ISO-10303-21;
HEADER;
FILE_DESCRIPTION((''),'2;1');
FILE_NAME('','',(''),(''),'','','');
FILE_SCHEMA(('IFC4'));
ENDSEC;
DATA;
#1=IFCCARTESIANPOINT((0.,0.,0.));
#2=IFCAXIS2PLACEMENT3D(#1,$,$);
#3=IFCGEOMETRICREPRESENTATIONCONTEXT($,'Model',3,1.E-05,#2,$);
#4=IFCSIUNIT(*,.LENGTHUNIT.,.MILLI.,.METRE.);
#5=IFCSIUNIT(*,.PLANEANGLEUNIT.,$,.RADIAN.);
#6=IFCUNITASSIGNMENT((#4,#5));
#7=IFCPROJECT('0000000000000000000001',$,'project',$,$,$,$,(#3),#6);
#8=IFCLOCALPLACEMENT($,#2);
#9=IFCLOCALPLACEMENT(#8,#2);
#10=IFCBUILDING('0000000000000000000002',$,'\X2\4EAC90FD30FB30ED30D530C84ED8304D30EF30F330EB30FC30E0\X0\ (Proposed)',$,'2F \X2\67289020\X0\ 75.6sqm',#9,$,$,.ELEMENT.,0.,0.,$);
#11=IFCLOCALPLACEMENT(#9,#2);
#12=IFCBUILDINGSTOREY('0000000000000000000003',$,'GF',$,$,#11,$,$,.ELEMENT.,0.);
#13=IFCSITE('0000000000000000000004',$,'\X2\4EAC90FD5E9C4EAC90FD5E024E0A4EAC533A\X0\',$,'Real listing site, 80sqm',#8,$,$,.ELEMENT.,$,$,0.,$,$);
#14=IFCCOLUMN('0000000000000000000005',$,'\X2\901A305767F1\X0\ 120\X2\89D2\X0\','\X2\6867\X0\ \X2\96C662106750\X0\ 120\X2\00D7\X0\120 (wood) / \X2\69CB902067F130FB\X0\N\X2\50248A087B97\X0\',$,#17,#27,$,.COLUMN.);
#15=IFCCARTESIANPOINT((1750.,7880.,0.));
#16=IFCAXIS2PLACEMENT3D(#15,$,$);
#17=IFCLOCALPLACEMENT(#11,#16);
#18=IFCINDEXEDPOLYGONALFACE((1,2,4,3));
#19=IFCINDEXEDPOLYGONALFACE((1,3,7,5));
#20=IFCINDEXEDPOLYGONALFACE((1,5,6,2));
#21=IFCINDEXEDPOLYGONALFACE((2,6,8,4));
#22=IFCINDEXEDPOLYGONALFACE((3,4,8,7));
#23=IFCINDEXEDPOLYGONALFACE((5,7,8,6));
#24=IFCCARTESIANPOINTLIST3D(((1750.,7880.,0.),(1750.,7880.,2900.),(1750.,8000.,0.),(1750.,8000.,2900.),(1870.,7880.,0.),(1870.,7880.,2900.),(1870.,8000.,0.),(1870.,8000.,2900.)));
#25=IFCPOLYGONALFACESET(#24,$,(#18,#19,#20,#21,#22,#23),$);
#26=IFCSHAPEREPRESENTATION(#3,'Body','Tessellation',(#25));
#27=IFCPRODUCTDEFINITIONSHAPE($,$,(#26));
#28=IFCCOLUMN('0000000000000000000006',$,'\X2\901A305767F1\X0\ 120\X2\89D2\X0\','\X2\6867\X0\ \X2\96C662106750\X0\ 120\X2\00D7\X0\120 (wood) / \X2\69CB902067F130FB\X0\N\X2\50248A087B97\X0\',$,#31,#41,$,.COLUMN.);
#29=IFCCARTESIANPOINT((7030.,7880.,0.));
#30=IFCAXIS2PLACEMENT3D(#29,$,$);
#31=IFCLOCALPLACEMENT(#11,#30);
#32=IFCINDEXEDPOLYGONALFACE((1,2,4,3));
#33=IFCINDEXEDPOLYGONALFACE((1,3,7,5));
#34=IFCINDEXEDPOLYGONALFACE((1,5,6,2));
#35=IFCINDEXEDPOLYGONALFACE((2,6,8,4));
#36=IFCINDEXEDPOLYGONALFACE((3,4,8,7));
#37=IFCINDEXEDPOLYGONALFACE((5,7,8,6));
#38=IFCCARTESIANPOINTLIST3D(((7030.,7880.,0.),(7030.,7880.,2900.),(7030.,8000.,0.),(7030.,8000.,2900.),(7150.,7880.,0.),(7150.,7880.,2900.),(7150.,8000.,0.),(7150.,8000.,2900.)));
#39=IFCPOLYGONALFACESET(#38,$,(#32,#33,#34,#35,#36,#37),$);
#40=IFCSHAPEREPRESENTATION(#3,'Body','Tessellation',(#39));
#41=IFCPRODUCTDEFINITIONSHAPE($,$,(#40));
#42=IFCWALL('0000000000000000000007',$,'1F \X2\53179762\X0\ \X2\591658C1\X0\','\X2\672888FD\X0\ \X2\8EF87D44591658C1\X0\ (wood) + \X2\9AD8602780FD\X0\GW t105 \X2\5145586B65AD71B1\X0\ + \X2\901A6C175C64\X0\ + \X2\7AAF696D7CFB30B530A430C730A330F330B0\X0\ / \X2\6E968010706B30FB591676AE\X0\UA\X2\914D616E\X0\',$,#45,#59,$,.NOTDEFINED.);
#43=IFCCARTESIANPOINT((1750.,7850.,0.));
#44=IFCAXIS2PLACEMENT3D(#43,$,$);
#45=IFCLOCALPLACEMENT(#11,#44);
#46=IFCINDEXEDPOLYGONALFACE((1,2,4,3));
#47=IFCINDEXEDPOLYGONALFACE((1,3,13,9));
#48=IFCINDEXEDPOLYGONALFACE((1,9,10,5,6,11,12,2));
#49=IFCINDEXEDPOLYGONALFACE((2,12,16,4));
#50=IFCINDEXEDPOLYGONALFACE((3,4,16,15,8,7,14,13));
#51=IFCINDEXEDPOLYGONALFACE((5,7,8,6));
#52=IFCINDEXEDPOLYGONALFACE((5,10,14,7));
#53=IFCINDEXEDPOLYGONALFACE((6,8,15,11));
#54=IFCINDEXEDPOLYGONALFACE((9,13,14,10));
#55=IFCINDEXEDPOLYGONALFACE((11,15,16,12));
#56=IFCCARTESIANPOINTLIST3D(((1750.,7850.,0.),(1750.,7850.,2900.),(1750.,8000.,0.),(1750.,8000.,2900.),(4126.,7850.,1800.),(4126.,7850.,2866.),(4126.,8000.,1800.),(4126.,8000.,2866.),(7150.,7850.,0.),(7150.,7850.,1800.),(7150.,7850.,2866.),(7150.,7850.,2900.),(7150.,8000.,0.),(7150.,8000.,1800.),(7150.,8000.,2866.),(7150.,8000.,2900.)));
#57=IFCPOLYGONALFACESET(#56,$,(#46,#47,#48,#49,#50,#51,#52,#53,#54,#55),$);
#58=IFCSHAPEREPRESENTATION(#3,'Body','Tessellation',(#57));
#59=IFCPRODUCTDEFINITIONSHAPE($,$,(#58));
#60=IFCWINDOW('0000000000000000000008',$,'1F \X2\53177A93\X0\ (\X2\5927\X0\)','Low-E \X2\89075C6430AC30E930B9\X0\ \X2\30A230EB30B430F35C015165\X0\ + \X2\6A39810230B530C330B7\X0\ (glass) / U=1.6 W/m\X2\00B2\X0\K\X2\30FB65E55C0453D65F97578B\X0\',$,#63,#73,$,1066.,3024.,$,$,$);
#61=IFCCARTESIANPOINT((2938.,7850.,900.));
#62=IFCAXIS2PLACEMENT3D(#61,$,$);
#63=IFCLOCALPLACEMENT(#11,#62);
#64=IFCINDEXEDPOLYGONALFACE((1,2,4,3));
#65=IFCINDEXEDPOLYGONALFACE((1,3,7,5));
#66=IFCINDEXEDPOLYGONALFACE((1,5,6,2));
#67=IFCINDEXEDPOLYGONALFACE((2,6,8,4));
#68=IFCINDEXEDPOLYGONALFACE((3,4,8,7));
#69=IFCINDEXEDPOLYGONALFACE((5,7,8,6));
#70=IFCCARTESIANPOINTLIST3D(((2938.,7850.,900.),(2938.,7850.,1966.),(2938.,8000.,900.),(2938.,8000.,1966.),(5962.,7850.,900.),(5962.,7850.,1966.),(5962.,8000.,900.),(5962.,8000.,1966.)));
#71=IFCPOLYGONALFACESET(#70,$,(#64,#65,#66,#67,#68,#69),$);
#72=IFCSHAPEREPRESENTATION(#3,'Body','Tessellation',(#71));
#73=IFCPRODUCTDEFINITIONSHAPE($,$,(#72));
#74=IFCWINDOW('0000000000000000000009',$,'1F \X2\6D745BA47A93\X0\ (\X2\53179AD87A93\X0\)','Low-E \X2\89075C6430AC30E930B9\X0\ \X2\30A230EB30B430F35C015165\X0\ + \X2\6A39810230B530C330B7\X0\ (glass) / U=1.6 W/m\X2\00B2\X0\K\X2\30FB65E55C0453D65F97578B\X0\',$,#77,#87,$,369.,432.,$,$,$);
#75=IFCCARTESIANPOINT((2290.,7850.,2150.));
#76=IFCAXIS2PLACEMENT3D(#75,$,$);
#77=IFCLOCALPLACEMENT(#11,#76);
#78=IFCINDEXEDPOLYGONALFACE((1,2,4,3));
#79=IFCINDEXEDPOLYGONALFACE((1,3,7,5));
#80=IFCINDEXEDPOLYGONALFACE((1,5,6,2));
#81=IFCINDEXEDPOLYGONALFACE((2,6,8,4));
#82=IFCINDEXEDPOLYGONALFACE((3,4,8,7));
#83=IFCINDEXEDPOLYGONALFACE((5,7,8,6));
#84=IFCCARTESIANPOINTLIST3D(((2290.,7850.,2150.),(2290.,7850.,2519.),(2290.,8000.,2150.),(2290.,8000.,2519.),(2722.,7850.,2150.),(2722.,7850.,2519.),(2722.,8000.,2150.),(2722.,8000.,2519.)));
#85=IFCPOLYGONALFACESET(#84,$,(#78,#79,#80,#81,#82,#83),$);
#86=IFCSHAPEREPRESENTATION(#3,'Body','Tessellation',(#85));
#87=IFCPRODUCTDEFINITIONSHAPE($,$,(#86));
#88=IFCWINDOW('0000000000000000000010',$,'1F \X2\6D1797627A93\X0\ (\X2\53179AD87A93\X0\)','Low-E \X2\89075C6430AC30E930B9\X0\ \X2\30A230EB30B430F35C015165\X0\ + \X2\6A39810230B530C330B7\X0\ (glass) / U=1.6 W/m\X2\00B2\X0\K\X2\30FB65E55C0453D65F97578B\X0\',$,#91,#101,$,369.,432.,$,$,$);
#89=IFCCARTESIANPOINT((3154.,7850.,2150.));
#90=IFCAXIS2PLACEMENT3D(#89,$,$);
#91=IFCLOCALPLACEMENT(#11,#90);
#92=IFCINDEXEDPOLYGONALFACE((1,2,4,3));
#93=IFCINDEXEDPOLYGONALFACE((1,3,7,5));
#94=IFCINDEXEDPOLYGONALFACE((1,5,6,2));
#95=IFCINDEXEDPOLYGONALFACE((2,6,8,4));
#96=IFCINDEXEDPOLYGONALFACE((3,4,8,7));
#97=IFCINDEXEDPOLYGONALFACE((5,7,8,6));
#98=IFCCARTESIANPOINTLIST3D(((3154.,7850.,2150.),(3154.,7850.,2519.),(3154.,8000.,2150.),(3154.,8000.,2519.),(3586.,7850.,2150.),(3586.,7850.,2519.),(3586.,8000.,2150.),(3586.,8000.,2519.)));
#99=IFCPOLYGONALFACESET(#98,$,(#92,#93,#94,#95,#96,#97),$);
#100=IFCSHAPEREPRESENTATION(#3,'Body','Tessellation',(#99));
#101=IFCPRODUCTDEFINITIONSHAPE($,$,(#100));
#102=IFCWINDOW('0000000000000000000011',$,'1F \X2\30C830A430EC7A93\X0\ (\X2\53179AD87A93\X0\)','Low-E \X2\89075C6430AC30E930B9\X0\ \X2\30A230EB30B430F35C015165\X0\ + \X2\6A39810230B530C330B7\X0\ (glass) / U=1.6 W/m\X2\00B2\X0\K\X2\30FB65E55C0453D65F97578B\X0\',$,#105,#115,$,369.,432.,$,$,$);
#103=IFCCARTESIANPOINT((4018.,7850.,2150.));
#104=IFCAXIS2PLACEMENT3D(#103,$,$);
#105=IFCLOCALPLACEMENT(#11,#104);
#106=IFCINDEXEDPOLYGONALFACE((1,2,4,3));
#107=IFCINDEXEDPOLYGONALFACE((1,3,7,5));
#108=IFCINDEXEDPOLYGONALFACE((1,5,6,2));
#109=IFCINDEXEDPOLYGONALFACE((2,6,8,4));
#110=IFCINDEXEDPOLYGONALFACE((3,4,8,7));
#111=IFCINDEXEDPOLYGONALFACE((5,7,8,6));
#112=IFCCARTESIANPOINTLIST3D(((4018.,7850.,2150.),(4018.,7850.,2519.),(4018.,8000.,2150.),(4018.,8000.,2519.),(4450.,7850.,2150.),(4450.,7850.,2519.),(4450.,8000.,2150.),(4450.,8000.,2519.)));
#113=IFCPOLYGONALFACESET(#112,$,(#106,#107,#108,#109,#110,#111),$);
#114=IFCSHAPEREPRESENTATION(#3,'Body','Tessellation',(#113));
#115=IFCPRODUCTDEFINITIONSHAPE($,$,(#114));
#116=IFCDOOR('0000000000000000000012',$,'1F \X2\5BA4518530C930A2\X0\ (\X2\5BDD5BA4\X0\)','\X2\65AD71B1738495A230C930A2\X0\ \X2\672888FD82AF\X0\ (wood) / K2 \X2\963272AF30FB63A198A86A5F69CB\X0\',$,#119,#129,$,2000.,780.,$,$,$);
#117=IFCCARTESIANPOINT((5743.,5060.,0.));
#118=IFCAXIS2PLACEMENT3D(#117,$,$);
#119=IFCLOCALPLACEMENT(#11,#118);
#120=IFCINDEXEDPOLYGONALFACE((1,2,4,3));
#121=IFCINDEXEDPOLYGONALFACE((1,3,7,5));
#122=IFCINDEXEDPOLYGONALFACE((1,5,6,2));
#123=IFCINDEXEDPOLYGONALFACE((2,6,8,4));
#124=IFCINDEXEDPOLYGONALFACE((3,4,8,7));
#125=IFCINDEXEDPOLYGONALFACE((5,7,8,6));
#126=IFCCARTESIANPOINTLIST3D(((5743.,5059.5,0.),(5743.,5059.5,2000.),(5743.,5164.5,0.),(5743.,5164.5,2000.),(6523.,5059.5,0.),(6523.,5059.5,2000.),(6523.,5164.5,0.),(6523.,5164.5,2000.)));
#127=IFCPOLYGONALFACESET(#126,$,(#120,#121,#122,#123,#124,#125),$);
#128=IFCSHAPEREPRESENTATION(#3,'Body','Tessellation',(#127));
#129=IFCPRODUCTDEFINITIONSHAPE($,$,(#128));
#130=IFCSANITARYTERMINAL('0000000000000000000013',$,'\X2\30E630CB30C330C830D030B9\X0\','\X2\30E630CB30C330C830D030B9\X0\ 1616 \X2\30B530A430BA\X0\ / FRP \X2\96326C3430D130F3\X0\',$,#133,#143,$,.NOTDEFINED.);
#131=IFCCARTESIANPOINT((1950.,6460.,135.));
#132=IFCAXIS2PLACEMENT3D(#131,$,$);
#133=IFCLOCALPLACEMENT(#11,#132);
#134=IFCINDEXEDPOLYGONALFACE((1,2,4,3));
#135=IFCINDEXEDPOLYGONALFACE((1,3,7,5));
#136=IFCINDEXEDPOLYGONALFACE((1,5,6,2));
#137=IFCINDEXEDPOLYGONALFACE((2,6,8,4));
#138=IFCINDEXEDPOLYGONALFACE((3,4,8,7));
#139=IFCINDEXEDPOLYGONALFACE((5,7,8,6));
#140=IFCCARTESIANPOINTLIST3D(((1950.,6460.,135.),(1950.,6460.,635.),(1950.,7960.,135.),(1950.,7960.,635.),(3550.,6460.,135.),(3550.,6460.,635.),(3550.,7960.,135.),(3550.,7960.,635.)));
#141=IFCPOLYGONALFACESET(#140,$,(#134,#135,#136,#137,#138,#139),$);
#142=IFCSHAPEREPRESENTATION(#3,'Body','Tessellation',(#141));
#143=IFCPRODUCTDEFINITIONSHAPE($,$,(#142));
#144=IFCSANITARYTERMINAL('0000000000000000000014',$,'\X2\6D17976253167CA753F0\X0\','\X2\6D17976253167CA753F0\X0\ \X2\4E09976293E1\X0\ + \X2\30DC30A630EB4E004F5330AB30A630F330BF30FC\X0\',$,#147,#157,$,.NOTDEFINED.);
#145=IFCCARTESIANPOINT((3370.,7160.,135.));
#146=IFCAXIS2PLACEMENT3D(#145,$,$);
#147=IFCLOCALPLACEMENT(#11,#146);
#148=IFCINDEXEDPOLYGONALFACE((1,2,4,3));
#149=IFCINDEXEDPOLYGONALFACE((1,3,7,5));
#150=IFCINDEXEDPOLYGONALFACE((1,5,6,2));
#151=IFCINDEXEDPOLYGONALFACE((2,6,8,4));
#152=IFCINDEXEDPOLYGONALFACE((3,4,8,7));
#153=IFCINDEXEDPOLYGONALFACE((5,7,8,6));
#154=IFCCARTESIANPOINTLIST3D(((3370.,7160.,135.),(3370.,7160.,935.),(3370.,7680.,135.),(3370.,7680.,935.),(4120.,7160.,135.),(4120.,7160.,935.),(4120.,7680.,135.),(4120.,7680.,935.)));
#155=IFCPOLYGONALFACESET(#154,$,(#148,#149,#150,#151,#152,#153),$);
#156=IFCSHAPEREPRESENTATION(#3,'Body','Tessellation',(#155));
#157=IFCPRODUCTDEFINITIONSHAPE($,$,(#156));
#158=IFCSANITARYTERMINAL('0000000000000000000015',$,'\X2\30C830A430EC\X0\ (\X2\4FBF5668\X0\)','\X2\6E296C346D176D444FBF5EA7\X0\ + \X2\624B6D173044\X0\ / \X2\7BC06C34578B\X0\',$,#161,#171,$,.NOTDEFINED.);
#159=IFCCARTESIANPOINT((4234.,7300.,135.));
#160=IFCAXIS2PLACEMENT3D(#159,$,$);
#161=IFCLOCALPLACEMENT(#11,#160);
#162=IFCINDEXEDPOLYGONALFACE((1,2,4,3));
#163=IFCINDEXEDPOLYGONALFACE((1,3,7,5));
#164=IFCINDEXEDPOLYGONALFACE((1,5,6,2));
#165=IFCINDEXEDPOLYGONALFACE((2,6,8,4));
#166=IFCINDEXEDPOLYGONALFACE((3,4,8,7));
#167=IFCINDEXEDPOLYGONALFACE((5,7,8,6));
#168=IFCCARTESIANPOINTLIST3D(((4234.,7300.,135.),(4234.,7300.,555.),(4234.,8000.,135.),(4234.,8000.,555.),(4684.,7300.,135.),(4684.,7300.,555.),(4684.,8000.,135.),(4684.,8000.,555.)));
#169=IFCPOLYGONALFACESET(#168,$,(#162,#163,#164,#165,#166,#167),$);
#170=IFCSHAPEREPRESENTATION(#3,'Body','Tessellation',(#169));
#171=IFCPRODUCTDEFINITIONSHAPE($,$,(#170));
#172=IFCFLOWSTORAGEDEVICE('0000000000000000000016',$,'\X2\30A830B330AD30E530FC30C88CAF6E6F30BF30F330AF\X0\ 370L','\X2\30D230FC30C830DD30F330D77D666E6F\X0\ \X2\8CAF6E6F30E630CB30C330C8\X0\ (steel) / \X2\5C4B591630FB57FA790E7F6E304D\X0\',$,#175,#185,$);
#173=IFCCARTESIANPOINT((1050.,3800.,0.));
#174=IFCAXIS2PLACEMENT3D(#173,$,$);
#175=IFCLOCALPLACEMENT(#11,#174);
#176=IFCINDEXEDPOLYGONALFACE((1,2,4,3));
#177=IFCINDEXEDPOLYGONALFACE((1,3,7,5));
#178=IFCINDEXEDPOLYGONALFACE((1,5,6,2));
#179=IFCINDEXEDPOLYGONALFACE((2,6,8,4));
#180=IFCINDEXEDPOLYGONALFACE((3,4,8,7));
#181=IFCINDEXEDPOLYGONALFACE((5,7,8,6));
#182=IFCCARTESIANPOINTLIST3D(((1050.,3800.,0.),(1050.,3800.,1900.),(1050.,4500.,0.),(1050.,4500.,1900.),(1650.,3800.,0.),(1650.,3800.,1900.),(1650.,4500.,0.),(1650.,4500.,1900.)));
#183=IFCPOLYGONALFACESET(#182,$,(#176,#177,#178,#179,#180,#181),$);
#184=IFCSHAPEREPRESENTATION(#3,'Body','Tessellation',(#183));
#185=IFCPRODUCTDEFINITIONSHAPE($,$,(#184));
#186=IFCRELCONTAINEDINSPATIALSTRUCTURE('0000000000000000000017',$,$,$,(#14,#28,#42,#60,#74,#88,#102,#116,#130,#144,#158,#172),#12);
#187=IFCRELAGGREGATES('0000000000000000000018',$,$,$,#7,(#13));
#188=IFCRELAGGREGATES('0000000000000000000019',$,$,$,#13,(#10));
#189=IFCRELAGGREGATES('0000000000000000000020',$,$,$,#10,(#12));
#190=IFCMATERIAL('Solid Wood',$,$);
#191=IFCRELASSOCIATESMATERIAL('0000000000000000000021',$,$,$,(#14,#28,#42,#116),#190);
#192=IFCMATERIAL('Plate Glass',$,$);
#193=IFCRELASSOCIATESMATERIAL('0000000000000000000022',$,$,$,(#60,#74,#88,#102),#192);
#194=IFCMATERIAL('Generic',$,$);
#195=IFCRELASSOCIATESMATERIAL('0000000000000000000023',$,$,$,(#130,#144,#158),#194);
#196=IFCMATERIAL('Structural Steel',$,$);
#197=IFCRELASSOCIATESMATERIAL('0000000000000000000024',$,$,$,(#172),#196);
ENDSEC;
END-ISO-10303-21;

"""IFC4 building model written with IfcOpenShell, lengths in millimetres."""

from ifc_helpers import new_model, si_unit, frame, frame_2d, origin, place, context, project, spatial, rectangle, extrude, material, element, fill, save


model = new_model("IFC4")

# Units and contexts
model_context = context("Model", 3, precision=1e-05, world=origin())
ifc_project = project(units=[si_unit("LENGTHUNIT", "METRE", prefix="MILLI"), si_unit("PLANEANGLEUNIT", "RADIAN")], contexts=[model_context])

# Site, building, storey
site_placement = place(None, origin())
site = spatial("IfcSite", under=ifc_project, at=site_placement, Name="京都府京都市上京区", ObjectType="Real listing site, 80sqm", CompositionType="ELEMENT", RefElevation=0.0)
building_placement = place(site_placement, origin())
building = spatial("IfcBuilding", under=site, at=building_placement, Name="京都・ロフト付きワンルーム (Proposed)", ObjectType="2F 木造 75.6sqm", CompositionType="ELEMENT", ElevationOfRefHeight=0.0, ElevationOfTerrain=0.0)
storey_placement = place(building_placement, origin())
storey = spatial("IfcBuildingStorey", under=building, at=storey_placement, Name="GF", CompositionType="ELEMENT", Elevation=0.0)

# Columns
ifc_material_1 = material(Name="Solid Wood")
column_1_placement = place(storey_placement, frame((1750.0, 7880.0, 0.0)))
element("IfcColumn", 1, at=column_1_placement, inside=storey, material=ifc_material_1, Name="通し柱 120角", Description="桧 集成材 120×120 (wood) / 構造柱・N値計算", PredefinedType="COLUMN", context=model_context, shape_type="SweptSolid", body=[
    extrude(rectangle(XDim=120.0, YDim=120.0, at=frame_2d((60.0, 60.0))), frame((1750.0, 7880.0, 0.0)), (0.0, 0.0, 1.0), 2900.0),
])
column_2_placement = place(storey_placement, frame((7030.0, 7880.0, 0.0)))
element("IfcColumn", 2, at=column_2_placement, inside=storey, material=ifc_material_1, Name="通し柱 120角", Description="桧 集成材 120×120 (wood) / 構造柱・N値計算", PredefinedType="COLUMN", context=model_context, shape_type="SweptSolid", body=[
    extrude(rectangle(XDim=120.0, YDim=120.0, at=frame_2d((60.0, 60.0))), frame((7030.0, 7880.0, 0.0)), (0.0, 0.0, 1.0), 2900.0),
])

# Wall, openings, windows
wall_1_placement = place(storey_placement, frame((1750.0, 7850.0, 0.0)))
wall_1 = element("IfcWall", 3, at=wall_1_placement, inside=storey, material=ifc_material_1, Name="1F 北面 外壁", Description="木製 軸組外壁 (wood) + 高性能GW t105 充填断熱 + 通気層 + 窯業系サイディング / 準耐火・外皮UA配慮", PredefinedType="NOTDEFINED", context=model_context, shape_type="SweptSolid", body=[
    extrude(rectangle(XDim=5400.0, YDim=150.0, at=frame_2d((2700.0, 75.0))), frame((1750.0, 7850.0, 0.0)), (0.0, 0.0, 1.0), 2900.0),
])
opening_1_placement = place(storey_placement, frame((2938.0, 7850.0, 900.0)))
opening_1 = element("IfcOpeningElement", 4, at=opening_1_placement, cuts=wall_1, PredefinedType="NOTDEFINED", context=model_context, shape_type="SweptSolid", body=[
    extrude(rectangle(XDim=3024.0, YDim=150.0, at=frame_2d((1512.0, 75.0))), frame((2938.0, 7850.0, 900.0)), (0.0, 0.0, 1.0), 1066.0),
])
opening_2_placement = place(storey_placement, frame((2290.0, 7850.0, 2150.0)))
opening_2 = element("IfcOpeningElement", 5, at=opening_2_placement, cuts=wall_1, PredefinedType="NOTDEFINED", context=model_context, shape_type="SweptSolid", body=[
    extrude(rectangle(XDim=432.0, YDim=150.0, at=frame_2d((216.0, 75.0))), frame((2290.0, 7850.0, 2150.0)), (0.0, 0.0, 1.0), 369.0),
])
opening_3_placement = place(storey_placement, frame((3154.0, 7850.0, 2150.0)))
opening_3 = element("IfcOpeningElement", 6, at=opening_3_placement, cuts=wall_1, PredefinedType="NOTDEFINED", context=model_context, shape_type="SweptSolid", body=[
    extrude(rectangle(XDim=432.0, YDim=150.0, at=frame_2d((216.0, 75.0))), frame((3154.0, 7850.0, 2150.0)), (0.0, 0.0, 1.0), 369.0),
])
opening_4_placement = place(storey_placement, frame((4018.0, 7850.0, 2150.0)))
opening_4 = element("IfcOpeningElement", 7, at=opening_4_placement, cuts=wall_1, PredefinedType="NOTDEFINED", context=model_context, shape_type="SweptSolid", body=[
    extrude(rectangle(XDim=432.0, YDim=150.0, at=frame_2d((216.0, 75.0))), frame((4018.0, 7850.0, 2150.0)), (0.0, 0.0, 1.0), 369.0),
])
ifc_material_2 = material(Name="Plate Glass")
window_1_placement = place(storey_placement, frame((2938.0, 7850.0, 900.0)))
window_1 = element("IfcWindow", 8, at=window_1_placement, inside=storey, material=ifc_material_2, Name="1F 北窓 (大)", Description="Low-E 複層ガラス アルゴン封入 + 樹脂サッシ (glass) / U=1.6 W/m²K・日射取得型", OverallHeight=1066.0, OverallWidth=3024.0, context=model_context, shape_type="SweptSolid", body=[
    extrude(rectangle(XDim=3024.0, YDim=150.0, at=frame_2d((1512.0, 75.0))), frame((2938.0, 7850.0, 900.0)), (0.0, 0.0, 1.0), 1066.0),
])
fill(opening_1, window_1)
window_2_placement = place(storey_placement, frame((2290.0, 7850.0, 2150.0)))
window_2 = element("IfcWindow", 9, at=window_2_placement, inside=storey, material=ifc_material_2, Name="1F 浴室窓 (北高窓)", Description="Low-E 複層ガラス アルゴン封入 + 樹脂サッシ (glass) / U=1.6 W/m²K・日射取得型", OverallHeight=369.0, OverallWidth=432.0, context=model_context, shape_type="SweptSolid", body=[
    extrude(rectangle(XDim=432.0, YDim=150.0, at=frame_2d((216.0, 75.0))), frame((2290.0, 7850.0, 2150.0)), (0.0, 0.0, 1.0), 369.0),
])
fill(opening_2, window_2)
window_3_placement = place(storey_placement, frame((3154.0, 7850.0, 2150.0)))
window_3 = element("IfcWindow", 10, at=window_3_placement, inside=storey, material=ifc_material_2, Name="1F 洗面窓 (北高窓)", Description="Low-E 複層ガラス アルゴン封入 + 樹脂サッシ (glass) / U=1.6 W/m²K・日射取得型", OverallHeight=369.0, OverallWidth=432.0, context=model_context, shape_type="SweptSolid", body=[
    extrude(rectangle(XDim=432.0, YDim=150.0, at=frame_2d((216.0, 75.0))), frame((3154.0, 7850.0, 2150.0)), (0.0, 0.0, 1.0), 369.0),
])
fill(opening_3, window_3)
window_4_placement = place(storey_placement, frame((4018.0, 7850.0, 2150.0)))
window_4 = element("IfcWindow", 11, at=window_4_placement, inside=storey, material=ifc_material_2, Name="1F トイレ窓 (北高窓)", Description="Low-E 複層ガラス アルゴン封入 + 樹脂サッシ (glass) / U=1.6 W/m²K・日射取得型", OverallHeight=369.0, OverallWidth=432.0, context=model_context, shape_type="SweptSolid", body=[
    extrude(rectangle(XDim=432.0, YDim=150.0, at=frame_2d((216.0, 75.0))), frame((4018.0, 7850.0, 2150.0)), (0.0, 0.0, 1.0), 369.0),
])
fill(opening_4, window_4)

# Door
door_1_placement = place(storey_placement, frame((5743.0, 5060.0, 0.0)))
element("IfcDoor", 12, at=door_1_placement, inside=storey, material=ifc_material_1, Name="1F 室内ドア (寝室)", Description="断熱玄関ドア 木製芯 (wood) / K2 防犯・採風機構", OverallHeight=2000.0, OverallWidth=780.0, context=model_context, shape_type="SweptSolid", body=[
    extrude(rectangle(XDim=780.0, YDim=105.0, at=frame_2d((390.0, 52.0))), frame((5743.0, 5060.0, 0.0)), (0.0, 0.0, 1.0), 2000.0),
])

# Sanitary terminals
ifc_material_3 = material(Name="Generic")
sanitary_terminal_1_placement = place(storey_placement, frame((1950.0, 6460.0, 135.0)))
element("IfcSanitaryTerminal", 13, at=sanitary_terminal_1_placement, inside=storey, material=ifc_material_3, Name="ユニットバス", Description="ユニットバス 1616 サイズ / FRP 防水パン", PredefinedType="NOTDEFINED", context=model_context, shape_type="SweptSolid", body=[
    extrude(rectangle(XDim=1600.0, YDim=1500.0, at=frame_2d((800.0, 750.0))), frame((1950.0, 6460.0, 135.0)), (0.0, 0.0, 1.0), 500.0),
])
sanitary_terminal_2_placement = place(storey_placement, frame((3370.0, 7160.0, 135.0)))
element("IfcSanitaryTerminal", 14, at=sanitary_terminal_2_placement, inside=storey, material=ifc_material_3, Name="洗面化粧台", Description="洗面化粧台 三面鏡 + ボウル一体カウンター", PredefinedType="NOTDEFINED", context=model_context, shape_type="SweptSolid", body=[
    extrude(rectangle(XDim=750.0, YDim=520.0, at=frame_2d((375.0, 260.0))), frame((3370.0, 7160.0, 135.0)), (0.0, 0.0, 1.0), 800.0),
])
sanitary_terminal_3_placement = place(storey_placement, frame((4234.0, 7300.0, 135.0)))
element("IfcSanitaryTerminal", 15, at=sanitary_terminal_3_placement, inside=storey, material=ifc_material_3, Name="トイレ (便器)", Description="温水洗浄便座 + 手洗い / 節水型", PredefinedType="NOTDEFINED", context=model_context, shape_type="SweptSolid", body=[
    extrude(rectangle(XDim=450.0, YDim=700.0, at=frame_2d((225.0, 350.0))), frame((4234.0, 7300.0, 135.0)), (0.0, 0.0, 1.0), 420.0),
])

# Flow storage device
ifc_material_4 = material(Name="Structural Steel")
flow_storage_device_placement = place(storey_placement, frame((1050.0, 3800.0, 0.0)))
element("IfcFlowStorageDevice", 16, at=flow_storage_device_placement, inside=storey, material=ifc_material_4, Name="エコキュート貯湯タンク 370L", Description="ヒートポンプ給湯 貯湯ユニット (steel) / 屋外・基礎置き", context=model_context, shape_type="SweptSolid", body=[
    extrude(rectangle(XDim=600.0, YDim=700.0, at=frame_2d((300.0, 350.0))), frame((1050.0, 3800.0, 0.0)), (0.0, 0.0, 1.0), 1900.0),
])

save(model, "model.ifc")
